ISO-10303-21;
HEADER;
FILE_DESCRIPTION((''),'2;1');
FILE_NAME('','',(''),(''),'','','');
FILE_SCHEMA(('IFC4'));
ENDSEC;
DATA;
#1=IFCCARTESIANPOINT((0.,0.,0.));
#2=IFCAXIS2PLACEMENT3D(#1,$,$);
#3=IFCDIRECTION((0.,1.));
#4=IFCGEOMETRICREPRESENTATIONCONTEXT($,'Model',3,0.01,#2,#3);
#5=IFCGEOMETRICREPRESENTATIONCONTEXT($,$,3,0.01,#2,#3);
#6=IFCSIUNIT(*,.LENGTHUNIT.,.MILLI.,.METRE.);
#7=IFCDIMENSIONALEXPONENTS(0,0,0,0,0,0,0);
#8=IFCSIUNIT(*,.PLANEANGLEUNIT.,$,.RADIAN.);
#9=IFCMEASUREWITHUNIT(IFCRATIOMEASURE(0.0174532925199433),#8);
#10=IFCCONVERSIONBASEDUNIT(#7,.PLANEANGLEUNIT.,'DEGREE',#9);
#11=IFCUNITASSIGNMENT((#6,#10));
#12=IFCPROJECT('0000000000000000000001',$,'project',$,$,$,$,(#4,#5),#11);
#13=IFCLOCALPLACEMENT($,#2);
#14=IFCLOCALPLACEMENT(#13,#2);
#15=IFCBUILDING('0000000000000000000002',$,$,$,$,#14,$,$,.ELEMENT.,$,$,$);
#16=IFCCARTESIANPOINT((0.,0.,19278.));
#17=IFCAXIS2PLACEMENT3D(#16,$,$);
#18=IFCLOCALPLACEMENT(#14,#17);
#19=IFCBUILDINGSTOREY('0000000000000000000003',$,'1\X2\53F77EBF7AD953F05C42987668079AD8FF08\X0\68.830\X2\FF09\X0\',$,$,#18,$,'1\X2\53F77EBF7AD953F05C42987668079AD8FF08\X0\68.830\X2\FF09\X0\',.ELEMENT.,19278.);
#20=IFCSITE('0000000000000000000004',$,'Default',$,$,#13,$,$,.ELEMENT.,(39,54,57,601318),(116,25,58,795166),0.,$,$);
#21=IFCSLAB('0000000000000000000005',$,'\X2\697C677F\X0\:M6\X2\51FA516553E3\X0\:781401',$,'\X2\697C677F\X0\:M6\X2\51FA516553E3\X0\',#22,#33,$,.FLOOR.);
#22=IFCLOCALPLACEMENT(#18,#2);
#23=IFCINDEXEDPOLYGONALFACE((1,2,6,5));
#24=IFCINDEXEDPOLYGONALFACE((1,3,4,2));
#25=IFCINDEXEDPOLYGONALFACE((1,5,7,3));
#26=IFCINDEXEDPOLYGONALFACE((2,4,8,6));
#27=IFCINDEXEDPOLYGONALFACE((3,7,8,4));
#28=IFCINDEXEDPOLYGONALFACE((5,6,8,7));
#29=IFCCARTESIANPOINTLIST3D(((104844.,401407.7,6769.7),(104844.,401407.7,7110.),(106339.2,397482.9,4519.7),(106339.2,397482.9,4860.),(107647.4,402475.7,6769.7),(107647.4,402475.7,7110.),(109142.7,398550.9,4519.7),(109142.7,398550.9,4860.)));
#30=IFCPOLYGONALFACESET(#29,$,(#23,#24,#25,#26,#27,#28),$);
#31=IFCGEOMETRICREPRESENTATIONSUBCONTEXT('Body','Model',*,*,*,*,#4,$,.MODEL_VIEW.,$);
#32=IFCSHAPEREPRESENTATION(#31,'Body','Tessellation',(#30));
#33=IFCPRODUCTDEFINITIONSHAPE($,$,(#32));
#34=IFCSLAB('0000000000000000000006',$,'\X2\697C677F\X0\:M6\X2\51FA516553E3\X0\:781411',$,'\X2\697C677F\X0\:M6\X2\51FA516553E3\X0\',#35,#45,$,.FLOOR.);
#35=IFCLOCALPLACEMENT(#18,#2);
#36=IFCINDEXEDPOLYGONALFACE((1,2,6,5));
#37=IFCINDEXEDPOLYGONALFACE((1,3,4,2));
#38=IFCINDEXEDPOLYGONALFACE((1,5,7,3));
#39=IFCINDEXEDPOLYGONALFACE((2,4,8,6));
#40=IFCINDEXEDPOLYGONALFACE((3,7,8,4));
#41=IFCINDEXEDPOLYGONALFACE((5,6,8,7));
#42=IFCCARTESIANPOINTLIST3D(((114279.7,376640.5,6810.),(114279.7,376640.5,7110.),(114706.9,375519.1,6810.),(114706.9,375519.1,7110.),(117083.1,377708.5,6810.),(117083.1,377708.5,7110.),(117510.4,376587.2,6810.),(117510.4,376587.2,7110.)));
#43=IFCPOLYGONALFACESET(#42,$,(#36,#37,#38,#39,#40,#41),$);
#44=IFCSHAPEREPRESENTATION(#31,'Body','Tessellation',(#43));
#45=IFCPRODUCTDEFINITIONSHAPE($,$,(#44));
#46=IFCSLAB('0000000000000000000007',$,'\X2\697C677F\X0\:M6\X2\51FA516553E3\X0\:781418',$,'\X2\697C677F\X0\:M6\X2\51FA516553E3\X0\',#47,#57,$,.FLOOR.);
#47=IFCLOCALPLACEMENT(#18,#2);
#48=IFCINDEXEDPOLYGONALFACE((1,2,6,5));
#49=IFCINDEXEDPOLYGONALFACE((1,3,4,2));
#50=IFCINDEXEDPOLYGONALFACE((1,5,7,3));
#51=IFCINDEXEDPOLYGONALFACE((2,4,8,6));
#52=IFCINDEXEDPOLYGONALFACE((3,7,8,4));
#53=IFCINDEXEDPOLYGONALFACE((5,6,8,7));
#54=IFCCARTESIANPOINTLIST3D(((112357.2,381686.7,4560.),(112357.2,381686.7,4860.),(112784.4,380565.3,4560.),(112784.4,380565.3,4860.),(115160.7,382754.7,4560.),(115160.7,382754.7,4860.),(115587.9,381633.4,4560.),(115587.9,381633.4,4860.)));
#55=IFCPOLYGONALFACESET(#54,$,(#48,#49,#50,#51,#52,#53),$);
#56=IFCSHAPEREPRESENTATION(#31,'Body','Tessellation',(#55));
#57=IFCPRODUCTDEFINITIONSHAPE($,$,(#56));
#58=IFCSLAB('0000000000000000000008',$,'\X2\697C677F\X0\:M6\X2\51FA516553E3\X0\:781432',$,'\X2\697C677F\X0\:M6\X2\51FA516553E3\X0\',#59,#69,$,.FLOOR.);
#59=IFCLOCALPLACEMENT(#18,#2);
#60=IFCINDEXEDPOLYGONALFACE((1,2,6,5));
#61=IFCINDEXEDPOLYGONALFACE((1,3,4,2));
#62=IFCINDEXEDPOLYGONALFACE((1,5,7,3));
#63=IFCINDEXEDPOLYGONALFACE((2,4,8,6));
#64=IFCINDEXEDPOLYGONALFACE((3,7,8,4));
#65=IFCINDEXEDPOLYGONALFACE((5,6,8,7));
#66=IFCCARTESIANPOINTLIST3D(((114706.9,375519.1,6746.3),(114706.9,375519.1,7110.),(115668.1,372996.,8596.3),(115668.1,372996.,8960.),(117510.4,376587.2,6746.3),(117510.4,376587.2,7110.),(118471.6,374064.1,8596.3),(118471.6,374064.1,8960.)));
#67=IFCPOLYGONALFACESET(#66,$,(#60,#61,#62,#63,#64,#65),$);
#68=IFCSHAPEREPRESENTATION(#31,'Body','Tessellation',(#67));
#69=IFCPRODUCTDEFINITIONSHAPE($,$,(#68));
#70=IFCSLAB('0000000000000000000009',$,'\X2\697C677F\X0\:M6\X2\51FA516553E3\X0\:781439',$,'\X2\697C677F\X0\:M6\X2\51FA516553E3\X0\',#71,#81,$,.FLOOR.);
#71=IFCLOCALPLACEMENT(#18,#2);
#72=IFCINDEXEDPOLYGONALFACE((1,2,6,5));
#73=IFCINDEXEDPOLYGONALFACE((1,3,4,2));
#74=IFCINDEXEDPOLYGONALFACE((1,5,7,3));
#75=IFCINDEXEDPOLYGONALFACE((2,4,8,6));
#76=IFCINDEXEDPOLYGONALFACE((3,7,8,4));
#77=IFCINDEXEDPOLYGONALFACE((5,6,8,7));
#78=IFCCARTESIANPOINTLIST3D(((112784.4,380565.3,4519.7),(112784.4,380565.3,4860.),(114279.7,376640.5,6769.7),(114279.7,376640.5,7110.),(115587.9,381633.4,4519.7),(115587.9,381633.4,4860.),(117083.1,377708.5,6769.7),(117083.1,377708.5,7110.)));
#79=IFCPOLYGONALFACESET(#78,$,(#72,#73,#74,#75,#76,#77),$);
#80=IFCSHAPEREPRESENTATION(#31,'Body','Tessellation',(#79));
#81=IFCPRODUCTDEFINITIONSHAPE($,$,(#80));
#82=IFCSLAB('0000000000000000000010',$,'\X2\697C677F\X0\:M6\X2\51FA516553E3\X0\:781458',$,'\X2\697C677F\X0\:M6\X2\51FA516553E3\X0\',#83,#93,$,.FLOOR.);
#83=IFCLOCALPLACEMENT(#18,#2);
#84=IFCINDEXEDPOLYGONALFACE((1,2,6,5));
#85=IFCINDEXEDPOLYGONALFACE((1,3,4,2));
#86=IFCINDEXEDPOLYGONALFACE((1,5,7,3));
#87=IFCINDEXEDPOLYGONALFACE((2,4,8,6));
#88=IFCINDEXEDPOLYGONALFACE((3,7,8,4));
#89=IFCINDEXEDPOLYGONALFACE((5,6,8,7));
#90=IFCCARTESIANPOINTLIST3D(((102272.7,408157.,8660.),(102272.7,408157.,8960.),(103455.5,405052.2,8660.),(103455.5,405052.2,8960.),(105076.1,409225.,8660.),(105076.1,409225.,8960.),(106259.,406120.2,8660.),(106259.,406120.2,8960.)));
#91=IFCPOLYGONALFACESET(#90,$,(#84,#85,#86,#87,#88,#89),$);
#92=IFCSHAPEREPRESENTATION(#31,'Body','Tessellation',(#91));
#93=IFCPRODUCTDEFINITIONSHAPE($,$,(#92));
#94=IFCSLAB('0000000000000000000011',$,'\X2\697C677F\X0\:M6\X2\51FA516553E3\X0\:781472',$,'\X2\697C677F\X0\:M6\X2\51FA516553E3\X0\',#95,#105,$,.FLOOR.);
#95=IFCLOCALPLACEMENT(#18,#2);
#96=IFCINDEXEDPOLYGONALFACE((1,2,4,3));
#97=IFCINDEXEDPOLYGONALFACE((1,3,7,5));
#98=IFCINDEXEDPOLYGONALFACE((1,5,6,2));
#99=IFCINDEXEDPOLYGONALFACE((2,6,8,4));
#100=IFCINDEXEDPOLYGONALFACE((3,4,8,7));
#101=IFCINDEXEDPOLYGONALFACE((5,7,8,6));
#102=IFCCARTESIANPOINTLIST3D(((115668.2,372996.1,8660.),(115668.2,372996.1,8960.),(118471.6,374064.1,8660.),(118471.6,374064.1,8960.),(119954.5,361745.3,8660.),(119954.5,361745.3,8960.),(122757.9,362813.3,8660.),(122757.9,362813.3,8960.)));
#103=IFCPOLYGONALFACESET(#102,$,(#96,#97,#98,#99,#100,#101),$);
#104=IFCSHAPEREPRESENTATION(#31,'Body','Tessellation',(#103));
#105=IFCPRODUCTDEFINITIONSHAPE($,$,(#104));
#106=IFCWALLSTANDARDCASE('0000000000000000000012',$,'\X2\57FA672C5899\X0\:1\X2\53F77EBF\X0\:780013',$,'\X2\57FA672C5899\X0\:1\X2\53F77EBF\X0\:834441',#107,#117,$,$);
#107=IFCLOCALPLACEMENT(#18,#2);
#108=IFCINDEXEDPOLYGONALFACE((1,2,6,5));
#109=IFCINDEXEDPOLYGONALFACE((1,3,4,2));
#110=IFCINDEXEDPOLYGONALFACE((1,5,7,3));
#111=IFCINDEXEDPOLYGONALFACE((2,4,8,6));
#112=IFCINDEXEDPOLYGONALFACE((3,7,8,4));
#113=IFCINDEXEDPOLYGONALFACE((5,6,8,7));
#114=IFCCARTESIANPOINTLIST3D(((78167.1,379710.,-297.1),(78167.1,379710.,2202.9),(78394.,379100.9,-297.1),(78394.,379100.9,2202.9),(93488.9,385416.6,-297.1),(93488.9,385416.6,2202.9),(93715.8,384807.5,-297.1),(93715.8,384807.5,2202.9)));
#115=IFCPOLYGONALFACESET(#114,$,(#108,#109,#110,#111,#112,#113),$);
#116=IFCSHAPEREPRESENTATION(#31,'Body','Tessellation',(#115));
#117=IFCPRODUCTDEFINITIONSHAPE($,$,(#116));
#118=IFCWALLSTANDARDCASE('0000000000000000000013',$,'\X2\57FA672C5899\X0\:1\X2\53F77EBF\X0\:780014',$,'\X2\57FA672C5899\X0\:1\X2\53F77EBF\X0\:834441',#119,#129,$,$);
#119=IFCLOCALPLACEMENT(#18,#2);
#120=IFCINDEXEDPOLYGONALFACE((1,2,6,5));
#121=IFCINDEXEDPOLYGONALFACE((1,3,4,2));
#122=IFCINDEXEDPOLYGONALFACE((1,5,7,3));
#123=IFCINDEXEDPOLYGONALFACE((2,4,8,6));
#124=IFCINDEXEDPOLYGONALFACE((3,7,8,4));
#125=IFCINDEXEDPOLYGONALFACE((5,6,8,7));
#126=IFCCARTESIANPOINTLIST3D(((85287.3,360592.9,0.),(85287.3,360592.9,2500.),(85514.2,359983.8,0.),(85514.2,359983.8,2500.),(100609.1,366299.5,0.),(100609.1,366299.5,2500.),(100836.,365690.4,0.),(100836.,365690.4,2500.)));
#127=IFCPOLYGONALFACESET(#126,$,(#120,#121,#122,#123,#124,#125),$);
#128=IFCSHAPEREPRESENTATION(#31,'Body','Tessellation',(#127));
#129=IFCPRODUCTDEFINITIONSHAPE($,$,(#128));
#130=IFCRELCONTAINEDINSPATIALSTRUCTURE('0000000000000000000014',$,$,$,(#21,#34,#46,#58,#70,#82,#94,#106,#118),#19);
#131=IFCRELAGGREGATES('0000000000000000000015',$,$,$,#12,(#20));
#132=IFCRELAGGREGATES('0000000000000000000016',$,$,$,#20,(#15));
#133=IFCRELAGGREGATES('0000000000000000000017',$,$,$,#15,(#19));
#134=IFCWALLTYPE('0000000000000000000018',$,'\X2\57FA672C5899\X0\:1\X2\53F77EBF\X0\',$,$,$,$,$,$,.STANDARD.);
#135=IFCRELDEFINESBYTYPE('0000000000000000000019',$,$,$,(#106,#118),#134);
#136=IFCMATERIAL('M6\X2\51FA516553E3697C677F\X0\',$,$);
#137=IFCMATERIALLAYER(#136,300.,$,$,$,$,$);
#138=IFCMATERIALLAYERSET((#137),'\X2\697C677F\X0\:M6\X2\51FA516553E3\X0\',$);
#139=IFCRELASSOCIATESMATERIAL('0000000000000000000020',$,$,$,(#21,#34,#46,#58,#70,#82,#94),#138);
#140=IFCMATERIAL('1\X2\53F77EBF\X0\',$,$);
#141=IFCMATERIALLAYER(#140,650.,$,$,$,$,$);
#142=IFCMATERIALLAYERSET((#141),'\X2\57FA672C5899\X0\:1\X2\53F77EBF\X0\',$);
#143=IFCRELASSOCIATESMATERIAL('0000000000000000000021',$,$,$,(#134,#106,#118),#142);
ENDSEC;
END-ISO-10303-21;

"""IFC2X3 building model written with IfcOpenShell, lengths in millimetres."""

from ifc_helpers import new_model, entity, si_unit, converted_unit, direction, frame, frame_2d, origin, origin_2d_with_axis, place, context, subcontext, project, spatial, polyline, rectangle, outline, extrude, clip, halfspace, material, layer, layer_set, layer_usage, type_object, element, save


model = new_model("IFC2X3")

# Units and contexts
model_context = context("Model", 3, precision=0.01, world=origin(), true_north=direction((0.0, 1.0)))
context_of_model = context(None, 3, precision=0.01, world=origin(), true_north=direction((0.0, 1.0)))
body_context = subcontext(model_context, "Body", "Model", "MODEL_VIEW")
ifc_project = project(units=[si_unit("LENGTHUNIT", "METRE", prefix="MILLI"), converted_unit("PLANEANGLEUNIT", "DEGREE", entity("IfcRatioMeasure", 0.0174532925199433), si_unit("PLANEANGLEUNIT", "RADIAN"), dimensions=[0, 0, 0, 0, 0, 0, 0])], contexts=[model_context, context_of_model])

# Site, building, storey
site_placement = place(None, origin())
site = spatial("IfcSite", under=ifc_project, at=site_placement, Name="Default", CompositionType="ELEMENT", RefLatitude=(39, 54, 57, 601318), RefLongitude=(116, 25, 58, 795166), RefElevation=0.0)
building_placement = place(site_placement, origin())
building = spatial("IfcBuilding", under=site, at=building_placement, CompositionType="ELEMENT")
storey_placement = place(building_placement, frame((0.0, 0.0, 19278.0)))
storey = spatial("IfcBuildingStorey", under=building, at=storey_placement, Name="1号线站台层顶标高（68.830）", LongName="1号线站台层顶标高（68.830）", CompositionType="ELEMENT", Elevation=19278.0)

# Slabs
ifc_material_1 = material(Name="1号线")
ifc_material_2 = material(Name="M6出入口楼板")
ifc_layer_1 = layer(ifc_material_2, 300.0)
ifc_layer_set_1 = layer_set([ifc_layer_1], Name="楼板:M6出入口")
ifc_layer_usage_1 = layer_usage(ifc_layer_set_1, "AXIS3", "POSITIVE", 0.0)
slab_1_placement = place(storey_placement, origin())
element("IfcSlab", 1, at=slab_1_placement, inside=storey, material=ifc_layer_usage_1, Name="楼板:M6出入口:781401", ObjectType="楼板:M6出入口", PredefinedType="FLOOR", context=body_context, shape_type="Clipping", body=[
    clip(clip(extrude(rectangle(XDim=4764.7, YDim=3000.0, at=frame_2d((0.0, 0.0), x_axis=(1.0, 0.0))), frame((106993.3, 399979.3, 5985.0), z_axis=(-0.168119, 0.441281, -0.88148), x_axis=(0.313822, -0.823725, -0.472221)), (0.472221, 0.0, 0.88148), 386.1), halfspace(frame((106245.7, 401941.7, 6769.7), z_axis=(-0.168119, 0.441281, -0.88148), x_axis=(0.985767, 0.075259, -0.150333)), False)), halfspace(frame((106245.7, 401941.7, 7110.0), z_axis=(0.168119, -0.441281, 0.88148), x_axis=(0.985767, 0.075259, -0.150333)), False)),
])
ifc_layer_usage_2 = layer_usage(ifc_layer_set_1, "AXIS3", "POSITIVE", 0.0)
slab_2_placement = place(storey_placement, origin())
element("IfcSlab", 2, at=slab_2_placement, inside=storey, material=ifc_layer_usage_2, Name="楼板:M6出入口:781411", ObjectType="楼板:M6出入口", PredefinedType="FLOOR", context=body_context, shape_type="SweptSolid", body=[
    extrude(rectangle(XDim=3000.0, YDim=1200.0, at=frame_2d((0.0, 0.0), x_axis=(1.0, 0.0))), frame((115895.0, 376613.8, 7110.0), z_axis=(0.0, 0.0, -1.0), x_axis=(0.934481, 0.356012, 0.0)), (0.0, 0.0, 1.0), 300.0),
])
ifc_layer_usage_3 = layer_usage(ifc_layer_set_1, "AXIS3", "POSITIVE", 0.0)
slab_3_placement = place(storey_placement, origin())
element("IfcSlab", 3, at=slab_3_placement, inside=storey, material=ifc_layer_usage_3, Name="楼板:M6出入口:781418", ObjectType="楼板:M6出入口", PredefinedType="FLOOR", context=body_context, shape_type="SweptSolid", body=[
    extrude(rectangle(XDim=3000.0, YDim=1200.0, at=origin_2d_with_axis()), frame((113972.6, 381660.0, 4860.0), z_axis=(0.0, 0.0, -1.0), x_axis=(0.934481, 0.356012, 0.0)), (0.0, 0.0, 1.0), 300.0),
])
ifc_layer_usage_4 = layer_usage(ifc_layer_set_1, "AXIS3", "POSITIVE", 0.0)
slab_4_placement = place(storey_placement, origin())
element("IfcSlab", 4, at=slab_4_placement, inside=storey, material=ifc_layer_usage_4, Name="楼板:M6出入口:781432", ObjectType="楼板:M6出入口", PredefinedType="FLOOR", context=body_context, shape_type="Clipping", body=[
    clip(clip(extrude(rectangle(XDim=3273.0, YDim=3000.0, at=frame_2d((0.0, 0.0), x_axis=(1.0, 0.0))), frame((116589.2, 374791.6, 8035.0), z_axis=(0.201229, -0.528198, -0.824932), x_axis=(0.293686, -0.770884, 0.565231)), (-0.565231, 0.0, 0.824932), 440.8), halfspace(frame((117069.9, 373530.0, 8596.3), z_axis=(0.201229, -0.528198, -0.824932), x_axis=(0.979544, 0.108509, 0.169467)), False)), halfspace(frame((117069.9, 373530.0, 8960.0), z_axis=(-0.201229, 0.528198, 0.824932), x_axis=(0.979544, 0.108509, 0.169467)), False)),
])
ifc_layer_usage_5 = layer_usage(ifc_layer_set_1, "AXIS3", "POSITIVE", 0.0)
slab_5_placement = place(storey_placement, origin())
element("IfcSlab", 5, at=slab_5_placement, inside=storey, material=ifc_layer_usage_5, Name="楼板:M6出入口:781439", ObjectType="楼板:M6出入口", PredefinedType="FLOOR", context=body_context, shape_type="Clipping", body=[
    clip(clip(extrude(rectangle(XDim=4764.7, YDim=3000.0, at=frame_2d((0.0, 0.0), x_axis=(1.0, 0.0))), frame((114933.8, 379136.9, 5985.0), z_axis=(0.168116, -0.441282, -0.88148), x_axis=(0.313817, -0.823727, 0.472221)), (-0.472221, 0.0, 0.88148), 386.1), halfspace(frame((115681.4, 377174.5, 6769.7), z_axis=(0.168116, -0.441282, -0.88148), x_axis=(0.985767, 0.075258, 0.150331)), False)), halfspace(frame((115681.4, 377174.5, 7110.0), z_axis=(-0.168116, 0.441282, 0.88148), x_axis=(0.985767, 0.075258, 0.150331)), False)),
])
ifc_layer_usage_6 = layer_usage(ifc_layer_set_1, "AXIS3", "POSITIVE", 0.0)
slab_6_placement = place(storey_placement, origin())
element("IfcSlab", 6, at=slab_6_placement, inside=storey, material=ifc_layer_usage_6, Name="楼板:M6出入口:781458", ObjectType="楼板:M6出入口", PredefinedType="FLOOR", context=body_context, shape_type="SweptSolid", body=[
    extrude(rectangle(XDim=3322.5, YDim=3000.0, at=frame_2d((0.0, 0.0), x_axis=(1.0, 0.0))), frame((104265.8, 407138.6, 8960.0), z_axis=(0.0, 0.0, -1.0), x_axis=(0.356017, -0.93448, 0.0)), (0.0, 0.0, 1.0), 300.0),
])
ifc_layer_usage_7 = layer_usage(ifc_layer_set_1, "AXIS3", "POSITIVE", 0.0)
slab_7_placement = place(storey_placement, origin())
element("IfcSlab", 7, at=slab_7_placement, inside=storey, material=ifc_layer_usage_7, Name="楼板:M6出入口:781472", ObjectType="楼板:M6出入口", PredefinedType="FLOOR", context=body_context, shape_type="SweptSolid", body=[
    extrude(outline(polyline([(-6019.8, -1500.0), (6019.8, -1500.0), (6019.8, 1500.0), (-6019.8, 1499.9), (-6019.8, -1500.0)])), frame((119213.0, 367904.7, 8960.0), z_axis=(0.0, 0.0, -1.0), x_axis=(0.356017, -0.93448, 0.0)), (0.0, 0.0, 1.0), 300.0),
])

# Walls
ifc_layer_2 = layer(ifc_material_1, 650.0)
ifc_layer_set_2 = layer_set([ifc_layer_2], Name="基本墙:1号线")
ifc_layer_usage_8 = layer_usage(ifc_layer_set_2, "AXIS2", "NEGATIVE", 325.0)
wall_type = type_object("IfcWallType", Name="基本墙:1号线", PredefinedType="STANDARD", material=ifc_layer_set_2)
wall_1_placement = place(storey_placement, frame((78280.6, 379405.4, -297.1), z_axis=(0.0, 0.0, 1.0), x_axis=(0.937112, 0.349028, 0.0)))
element("IfcWallStandardCase", 8, at=wall_1_placement, inside=storey, type_object=wall_type, material=ifc_layer_usage_8, Name="基本墙:1号线:780013", ObjectType="基本墙:1号线:834441", context=body_context, shape_type="SweptSolid", body=[
    extrude(rectangle(XDim=16350.0, YDim=650.0, at=frame_2d((8175.0, 0.0), x_axis=(-1.0, 0.0))), origin(), (0.0, 0.0, 1.0), 2500.0),
])
ifc_layer_usage_9 = layer_usage(ifc_layer_set_2, "AXIS2", "NEGATIVE", 325.0)
wall_2_placement = place(storey_placement, frame((85400.7, 360288.3, 0.0), z_axis=(0.0, 0.0, 1.0), x_axis=(0.937112, 0.349028, 0.0)))
element("IfcWallStandardCase", 9, at=wall_2_placement, inside=storey, type_object=wall_type, material=ifc_layer_usage_9, Name="基本墙:1号线:780014", ObjectType="基本墙:1号线:834441", context=body_context, shape_type="SweptSolid", body=[
    extrude(rectangle(XDim=16350.0, YDim=650.0, at=frame_2d((8175.0, 0.0), x_axis=(-1.0, 0.0))), origin(), (0.0, 0.0, 1.0), 2500.0),
])

save(model, "model.ifc")
